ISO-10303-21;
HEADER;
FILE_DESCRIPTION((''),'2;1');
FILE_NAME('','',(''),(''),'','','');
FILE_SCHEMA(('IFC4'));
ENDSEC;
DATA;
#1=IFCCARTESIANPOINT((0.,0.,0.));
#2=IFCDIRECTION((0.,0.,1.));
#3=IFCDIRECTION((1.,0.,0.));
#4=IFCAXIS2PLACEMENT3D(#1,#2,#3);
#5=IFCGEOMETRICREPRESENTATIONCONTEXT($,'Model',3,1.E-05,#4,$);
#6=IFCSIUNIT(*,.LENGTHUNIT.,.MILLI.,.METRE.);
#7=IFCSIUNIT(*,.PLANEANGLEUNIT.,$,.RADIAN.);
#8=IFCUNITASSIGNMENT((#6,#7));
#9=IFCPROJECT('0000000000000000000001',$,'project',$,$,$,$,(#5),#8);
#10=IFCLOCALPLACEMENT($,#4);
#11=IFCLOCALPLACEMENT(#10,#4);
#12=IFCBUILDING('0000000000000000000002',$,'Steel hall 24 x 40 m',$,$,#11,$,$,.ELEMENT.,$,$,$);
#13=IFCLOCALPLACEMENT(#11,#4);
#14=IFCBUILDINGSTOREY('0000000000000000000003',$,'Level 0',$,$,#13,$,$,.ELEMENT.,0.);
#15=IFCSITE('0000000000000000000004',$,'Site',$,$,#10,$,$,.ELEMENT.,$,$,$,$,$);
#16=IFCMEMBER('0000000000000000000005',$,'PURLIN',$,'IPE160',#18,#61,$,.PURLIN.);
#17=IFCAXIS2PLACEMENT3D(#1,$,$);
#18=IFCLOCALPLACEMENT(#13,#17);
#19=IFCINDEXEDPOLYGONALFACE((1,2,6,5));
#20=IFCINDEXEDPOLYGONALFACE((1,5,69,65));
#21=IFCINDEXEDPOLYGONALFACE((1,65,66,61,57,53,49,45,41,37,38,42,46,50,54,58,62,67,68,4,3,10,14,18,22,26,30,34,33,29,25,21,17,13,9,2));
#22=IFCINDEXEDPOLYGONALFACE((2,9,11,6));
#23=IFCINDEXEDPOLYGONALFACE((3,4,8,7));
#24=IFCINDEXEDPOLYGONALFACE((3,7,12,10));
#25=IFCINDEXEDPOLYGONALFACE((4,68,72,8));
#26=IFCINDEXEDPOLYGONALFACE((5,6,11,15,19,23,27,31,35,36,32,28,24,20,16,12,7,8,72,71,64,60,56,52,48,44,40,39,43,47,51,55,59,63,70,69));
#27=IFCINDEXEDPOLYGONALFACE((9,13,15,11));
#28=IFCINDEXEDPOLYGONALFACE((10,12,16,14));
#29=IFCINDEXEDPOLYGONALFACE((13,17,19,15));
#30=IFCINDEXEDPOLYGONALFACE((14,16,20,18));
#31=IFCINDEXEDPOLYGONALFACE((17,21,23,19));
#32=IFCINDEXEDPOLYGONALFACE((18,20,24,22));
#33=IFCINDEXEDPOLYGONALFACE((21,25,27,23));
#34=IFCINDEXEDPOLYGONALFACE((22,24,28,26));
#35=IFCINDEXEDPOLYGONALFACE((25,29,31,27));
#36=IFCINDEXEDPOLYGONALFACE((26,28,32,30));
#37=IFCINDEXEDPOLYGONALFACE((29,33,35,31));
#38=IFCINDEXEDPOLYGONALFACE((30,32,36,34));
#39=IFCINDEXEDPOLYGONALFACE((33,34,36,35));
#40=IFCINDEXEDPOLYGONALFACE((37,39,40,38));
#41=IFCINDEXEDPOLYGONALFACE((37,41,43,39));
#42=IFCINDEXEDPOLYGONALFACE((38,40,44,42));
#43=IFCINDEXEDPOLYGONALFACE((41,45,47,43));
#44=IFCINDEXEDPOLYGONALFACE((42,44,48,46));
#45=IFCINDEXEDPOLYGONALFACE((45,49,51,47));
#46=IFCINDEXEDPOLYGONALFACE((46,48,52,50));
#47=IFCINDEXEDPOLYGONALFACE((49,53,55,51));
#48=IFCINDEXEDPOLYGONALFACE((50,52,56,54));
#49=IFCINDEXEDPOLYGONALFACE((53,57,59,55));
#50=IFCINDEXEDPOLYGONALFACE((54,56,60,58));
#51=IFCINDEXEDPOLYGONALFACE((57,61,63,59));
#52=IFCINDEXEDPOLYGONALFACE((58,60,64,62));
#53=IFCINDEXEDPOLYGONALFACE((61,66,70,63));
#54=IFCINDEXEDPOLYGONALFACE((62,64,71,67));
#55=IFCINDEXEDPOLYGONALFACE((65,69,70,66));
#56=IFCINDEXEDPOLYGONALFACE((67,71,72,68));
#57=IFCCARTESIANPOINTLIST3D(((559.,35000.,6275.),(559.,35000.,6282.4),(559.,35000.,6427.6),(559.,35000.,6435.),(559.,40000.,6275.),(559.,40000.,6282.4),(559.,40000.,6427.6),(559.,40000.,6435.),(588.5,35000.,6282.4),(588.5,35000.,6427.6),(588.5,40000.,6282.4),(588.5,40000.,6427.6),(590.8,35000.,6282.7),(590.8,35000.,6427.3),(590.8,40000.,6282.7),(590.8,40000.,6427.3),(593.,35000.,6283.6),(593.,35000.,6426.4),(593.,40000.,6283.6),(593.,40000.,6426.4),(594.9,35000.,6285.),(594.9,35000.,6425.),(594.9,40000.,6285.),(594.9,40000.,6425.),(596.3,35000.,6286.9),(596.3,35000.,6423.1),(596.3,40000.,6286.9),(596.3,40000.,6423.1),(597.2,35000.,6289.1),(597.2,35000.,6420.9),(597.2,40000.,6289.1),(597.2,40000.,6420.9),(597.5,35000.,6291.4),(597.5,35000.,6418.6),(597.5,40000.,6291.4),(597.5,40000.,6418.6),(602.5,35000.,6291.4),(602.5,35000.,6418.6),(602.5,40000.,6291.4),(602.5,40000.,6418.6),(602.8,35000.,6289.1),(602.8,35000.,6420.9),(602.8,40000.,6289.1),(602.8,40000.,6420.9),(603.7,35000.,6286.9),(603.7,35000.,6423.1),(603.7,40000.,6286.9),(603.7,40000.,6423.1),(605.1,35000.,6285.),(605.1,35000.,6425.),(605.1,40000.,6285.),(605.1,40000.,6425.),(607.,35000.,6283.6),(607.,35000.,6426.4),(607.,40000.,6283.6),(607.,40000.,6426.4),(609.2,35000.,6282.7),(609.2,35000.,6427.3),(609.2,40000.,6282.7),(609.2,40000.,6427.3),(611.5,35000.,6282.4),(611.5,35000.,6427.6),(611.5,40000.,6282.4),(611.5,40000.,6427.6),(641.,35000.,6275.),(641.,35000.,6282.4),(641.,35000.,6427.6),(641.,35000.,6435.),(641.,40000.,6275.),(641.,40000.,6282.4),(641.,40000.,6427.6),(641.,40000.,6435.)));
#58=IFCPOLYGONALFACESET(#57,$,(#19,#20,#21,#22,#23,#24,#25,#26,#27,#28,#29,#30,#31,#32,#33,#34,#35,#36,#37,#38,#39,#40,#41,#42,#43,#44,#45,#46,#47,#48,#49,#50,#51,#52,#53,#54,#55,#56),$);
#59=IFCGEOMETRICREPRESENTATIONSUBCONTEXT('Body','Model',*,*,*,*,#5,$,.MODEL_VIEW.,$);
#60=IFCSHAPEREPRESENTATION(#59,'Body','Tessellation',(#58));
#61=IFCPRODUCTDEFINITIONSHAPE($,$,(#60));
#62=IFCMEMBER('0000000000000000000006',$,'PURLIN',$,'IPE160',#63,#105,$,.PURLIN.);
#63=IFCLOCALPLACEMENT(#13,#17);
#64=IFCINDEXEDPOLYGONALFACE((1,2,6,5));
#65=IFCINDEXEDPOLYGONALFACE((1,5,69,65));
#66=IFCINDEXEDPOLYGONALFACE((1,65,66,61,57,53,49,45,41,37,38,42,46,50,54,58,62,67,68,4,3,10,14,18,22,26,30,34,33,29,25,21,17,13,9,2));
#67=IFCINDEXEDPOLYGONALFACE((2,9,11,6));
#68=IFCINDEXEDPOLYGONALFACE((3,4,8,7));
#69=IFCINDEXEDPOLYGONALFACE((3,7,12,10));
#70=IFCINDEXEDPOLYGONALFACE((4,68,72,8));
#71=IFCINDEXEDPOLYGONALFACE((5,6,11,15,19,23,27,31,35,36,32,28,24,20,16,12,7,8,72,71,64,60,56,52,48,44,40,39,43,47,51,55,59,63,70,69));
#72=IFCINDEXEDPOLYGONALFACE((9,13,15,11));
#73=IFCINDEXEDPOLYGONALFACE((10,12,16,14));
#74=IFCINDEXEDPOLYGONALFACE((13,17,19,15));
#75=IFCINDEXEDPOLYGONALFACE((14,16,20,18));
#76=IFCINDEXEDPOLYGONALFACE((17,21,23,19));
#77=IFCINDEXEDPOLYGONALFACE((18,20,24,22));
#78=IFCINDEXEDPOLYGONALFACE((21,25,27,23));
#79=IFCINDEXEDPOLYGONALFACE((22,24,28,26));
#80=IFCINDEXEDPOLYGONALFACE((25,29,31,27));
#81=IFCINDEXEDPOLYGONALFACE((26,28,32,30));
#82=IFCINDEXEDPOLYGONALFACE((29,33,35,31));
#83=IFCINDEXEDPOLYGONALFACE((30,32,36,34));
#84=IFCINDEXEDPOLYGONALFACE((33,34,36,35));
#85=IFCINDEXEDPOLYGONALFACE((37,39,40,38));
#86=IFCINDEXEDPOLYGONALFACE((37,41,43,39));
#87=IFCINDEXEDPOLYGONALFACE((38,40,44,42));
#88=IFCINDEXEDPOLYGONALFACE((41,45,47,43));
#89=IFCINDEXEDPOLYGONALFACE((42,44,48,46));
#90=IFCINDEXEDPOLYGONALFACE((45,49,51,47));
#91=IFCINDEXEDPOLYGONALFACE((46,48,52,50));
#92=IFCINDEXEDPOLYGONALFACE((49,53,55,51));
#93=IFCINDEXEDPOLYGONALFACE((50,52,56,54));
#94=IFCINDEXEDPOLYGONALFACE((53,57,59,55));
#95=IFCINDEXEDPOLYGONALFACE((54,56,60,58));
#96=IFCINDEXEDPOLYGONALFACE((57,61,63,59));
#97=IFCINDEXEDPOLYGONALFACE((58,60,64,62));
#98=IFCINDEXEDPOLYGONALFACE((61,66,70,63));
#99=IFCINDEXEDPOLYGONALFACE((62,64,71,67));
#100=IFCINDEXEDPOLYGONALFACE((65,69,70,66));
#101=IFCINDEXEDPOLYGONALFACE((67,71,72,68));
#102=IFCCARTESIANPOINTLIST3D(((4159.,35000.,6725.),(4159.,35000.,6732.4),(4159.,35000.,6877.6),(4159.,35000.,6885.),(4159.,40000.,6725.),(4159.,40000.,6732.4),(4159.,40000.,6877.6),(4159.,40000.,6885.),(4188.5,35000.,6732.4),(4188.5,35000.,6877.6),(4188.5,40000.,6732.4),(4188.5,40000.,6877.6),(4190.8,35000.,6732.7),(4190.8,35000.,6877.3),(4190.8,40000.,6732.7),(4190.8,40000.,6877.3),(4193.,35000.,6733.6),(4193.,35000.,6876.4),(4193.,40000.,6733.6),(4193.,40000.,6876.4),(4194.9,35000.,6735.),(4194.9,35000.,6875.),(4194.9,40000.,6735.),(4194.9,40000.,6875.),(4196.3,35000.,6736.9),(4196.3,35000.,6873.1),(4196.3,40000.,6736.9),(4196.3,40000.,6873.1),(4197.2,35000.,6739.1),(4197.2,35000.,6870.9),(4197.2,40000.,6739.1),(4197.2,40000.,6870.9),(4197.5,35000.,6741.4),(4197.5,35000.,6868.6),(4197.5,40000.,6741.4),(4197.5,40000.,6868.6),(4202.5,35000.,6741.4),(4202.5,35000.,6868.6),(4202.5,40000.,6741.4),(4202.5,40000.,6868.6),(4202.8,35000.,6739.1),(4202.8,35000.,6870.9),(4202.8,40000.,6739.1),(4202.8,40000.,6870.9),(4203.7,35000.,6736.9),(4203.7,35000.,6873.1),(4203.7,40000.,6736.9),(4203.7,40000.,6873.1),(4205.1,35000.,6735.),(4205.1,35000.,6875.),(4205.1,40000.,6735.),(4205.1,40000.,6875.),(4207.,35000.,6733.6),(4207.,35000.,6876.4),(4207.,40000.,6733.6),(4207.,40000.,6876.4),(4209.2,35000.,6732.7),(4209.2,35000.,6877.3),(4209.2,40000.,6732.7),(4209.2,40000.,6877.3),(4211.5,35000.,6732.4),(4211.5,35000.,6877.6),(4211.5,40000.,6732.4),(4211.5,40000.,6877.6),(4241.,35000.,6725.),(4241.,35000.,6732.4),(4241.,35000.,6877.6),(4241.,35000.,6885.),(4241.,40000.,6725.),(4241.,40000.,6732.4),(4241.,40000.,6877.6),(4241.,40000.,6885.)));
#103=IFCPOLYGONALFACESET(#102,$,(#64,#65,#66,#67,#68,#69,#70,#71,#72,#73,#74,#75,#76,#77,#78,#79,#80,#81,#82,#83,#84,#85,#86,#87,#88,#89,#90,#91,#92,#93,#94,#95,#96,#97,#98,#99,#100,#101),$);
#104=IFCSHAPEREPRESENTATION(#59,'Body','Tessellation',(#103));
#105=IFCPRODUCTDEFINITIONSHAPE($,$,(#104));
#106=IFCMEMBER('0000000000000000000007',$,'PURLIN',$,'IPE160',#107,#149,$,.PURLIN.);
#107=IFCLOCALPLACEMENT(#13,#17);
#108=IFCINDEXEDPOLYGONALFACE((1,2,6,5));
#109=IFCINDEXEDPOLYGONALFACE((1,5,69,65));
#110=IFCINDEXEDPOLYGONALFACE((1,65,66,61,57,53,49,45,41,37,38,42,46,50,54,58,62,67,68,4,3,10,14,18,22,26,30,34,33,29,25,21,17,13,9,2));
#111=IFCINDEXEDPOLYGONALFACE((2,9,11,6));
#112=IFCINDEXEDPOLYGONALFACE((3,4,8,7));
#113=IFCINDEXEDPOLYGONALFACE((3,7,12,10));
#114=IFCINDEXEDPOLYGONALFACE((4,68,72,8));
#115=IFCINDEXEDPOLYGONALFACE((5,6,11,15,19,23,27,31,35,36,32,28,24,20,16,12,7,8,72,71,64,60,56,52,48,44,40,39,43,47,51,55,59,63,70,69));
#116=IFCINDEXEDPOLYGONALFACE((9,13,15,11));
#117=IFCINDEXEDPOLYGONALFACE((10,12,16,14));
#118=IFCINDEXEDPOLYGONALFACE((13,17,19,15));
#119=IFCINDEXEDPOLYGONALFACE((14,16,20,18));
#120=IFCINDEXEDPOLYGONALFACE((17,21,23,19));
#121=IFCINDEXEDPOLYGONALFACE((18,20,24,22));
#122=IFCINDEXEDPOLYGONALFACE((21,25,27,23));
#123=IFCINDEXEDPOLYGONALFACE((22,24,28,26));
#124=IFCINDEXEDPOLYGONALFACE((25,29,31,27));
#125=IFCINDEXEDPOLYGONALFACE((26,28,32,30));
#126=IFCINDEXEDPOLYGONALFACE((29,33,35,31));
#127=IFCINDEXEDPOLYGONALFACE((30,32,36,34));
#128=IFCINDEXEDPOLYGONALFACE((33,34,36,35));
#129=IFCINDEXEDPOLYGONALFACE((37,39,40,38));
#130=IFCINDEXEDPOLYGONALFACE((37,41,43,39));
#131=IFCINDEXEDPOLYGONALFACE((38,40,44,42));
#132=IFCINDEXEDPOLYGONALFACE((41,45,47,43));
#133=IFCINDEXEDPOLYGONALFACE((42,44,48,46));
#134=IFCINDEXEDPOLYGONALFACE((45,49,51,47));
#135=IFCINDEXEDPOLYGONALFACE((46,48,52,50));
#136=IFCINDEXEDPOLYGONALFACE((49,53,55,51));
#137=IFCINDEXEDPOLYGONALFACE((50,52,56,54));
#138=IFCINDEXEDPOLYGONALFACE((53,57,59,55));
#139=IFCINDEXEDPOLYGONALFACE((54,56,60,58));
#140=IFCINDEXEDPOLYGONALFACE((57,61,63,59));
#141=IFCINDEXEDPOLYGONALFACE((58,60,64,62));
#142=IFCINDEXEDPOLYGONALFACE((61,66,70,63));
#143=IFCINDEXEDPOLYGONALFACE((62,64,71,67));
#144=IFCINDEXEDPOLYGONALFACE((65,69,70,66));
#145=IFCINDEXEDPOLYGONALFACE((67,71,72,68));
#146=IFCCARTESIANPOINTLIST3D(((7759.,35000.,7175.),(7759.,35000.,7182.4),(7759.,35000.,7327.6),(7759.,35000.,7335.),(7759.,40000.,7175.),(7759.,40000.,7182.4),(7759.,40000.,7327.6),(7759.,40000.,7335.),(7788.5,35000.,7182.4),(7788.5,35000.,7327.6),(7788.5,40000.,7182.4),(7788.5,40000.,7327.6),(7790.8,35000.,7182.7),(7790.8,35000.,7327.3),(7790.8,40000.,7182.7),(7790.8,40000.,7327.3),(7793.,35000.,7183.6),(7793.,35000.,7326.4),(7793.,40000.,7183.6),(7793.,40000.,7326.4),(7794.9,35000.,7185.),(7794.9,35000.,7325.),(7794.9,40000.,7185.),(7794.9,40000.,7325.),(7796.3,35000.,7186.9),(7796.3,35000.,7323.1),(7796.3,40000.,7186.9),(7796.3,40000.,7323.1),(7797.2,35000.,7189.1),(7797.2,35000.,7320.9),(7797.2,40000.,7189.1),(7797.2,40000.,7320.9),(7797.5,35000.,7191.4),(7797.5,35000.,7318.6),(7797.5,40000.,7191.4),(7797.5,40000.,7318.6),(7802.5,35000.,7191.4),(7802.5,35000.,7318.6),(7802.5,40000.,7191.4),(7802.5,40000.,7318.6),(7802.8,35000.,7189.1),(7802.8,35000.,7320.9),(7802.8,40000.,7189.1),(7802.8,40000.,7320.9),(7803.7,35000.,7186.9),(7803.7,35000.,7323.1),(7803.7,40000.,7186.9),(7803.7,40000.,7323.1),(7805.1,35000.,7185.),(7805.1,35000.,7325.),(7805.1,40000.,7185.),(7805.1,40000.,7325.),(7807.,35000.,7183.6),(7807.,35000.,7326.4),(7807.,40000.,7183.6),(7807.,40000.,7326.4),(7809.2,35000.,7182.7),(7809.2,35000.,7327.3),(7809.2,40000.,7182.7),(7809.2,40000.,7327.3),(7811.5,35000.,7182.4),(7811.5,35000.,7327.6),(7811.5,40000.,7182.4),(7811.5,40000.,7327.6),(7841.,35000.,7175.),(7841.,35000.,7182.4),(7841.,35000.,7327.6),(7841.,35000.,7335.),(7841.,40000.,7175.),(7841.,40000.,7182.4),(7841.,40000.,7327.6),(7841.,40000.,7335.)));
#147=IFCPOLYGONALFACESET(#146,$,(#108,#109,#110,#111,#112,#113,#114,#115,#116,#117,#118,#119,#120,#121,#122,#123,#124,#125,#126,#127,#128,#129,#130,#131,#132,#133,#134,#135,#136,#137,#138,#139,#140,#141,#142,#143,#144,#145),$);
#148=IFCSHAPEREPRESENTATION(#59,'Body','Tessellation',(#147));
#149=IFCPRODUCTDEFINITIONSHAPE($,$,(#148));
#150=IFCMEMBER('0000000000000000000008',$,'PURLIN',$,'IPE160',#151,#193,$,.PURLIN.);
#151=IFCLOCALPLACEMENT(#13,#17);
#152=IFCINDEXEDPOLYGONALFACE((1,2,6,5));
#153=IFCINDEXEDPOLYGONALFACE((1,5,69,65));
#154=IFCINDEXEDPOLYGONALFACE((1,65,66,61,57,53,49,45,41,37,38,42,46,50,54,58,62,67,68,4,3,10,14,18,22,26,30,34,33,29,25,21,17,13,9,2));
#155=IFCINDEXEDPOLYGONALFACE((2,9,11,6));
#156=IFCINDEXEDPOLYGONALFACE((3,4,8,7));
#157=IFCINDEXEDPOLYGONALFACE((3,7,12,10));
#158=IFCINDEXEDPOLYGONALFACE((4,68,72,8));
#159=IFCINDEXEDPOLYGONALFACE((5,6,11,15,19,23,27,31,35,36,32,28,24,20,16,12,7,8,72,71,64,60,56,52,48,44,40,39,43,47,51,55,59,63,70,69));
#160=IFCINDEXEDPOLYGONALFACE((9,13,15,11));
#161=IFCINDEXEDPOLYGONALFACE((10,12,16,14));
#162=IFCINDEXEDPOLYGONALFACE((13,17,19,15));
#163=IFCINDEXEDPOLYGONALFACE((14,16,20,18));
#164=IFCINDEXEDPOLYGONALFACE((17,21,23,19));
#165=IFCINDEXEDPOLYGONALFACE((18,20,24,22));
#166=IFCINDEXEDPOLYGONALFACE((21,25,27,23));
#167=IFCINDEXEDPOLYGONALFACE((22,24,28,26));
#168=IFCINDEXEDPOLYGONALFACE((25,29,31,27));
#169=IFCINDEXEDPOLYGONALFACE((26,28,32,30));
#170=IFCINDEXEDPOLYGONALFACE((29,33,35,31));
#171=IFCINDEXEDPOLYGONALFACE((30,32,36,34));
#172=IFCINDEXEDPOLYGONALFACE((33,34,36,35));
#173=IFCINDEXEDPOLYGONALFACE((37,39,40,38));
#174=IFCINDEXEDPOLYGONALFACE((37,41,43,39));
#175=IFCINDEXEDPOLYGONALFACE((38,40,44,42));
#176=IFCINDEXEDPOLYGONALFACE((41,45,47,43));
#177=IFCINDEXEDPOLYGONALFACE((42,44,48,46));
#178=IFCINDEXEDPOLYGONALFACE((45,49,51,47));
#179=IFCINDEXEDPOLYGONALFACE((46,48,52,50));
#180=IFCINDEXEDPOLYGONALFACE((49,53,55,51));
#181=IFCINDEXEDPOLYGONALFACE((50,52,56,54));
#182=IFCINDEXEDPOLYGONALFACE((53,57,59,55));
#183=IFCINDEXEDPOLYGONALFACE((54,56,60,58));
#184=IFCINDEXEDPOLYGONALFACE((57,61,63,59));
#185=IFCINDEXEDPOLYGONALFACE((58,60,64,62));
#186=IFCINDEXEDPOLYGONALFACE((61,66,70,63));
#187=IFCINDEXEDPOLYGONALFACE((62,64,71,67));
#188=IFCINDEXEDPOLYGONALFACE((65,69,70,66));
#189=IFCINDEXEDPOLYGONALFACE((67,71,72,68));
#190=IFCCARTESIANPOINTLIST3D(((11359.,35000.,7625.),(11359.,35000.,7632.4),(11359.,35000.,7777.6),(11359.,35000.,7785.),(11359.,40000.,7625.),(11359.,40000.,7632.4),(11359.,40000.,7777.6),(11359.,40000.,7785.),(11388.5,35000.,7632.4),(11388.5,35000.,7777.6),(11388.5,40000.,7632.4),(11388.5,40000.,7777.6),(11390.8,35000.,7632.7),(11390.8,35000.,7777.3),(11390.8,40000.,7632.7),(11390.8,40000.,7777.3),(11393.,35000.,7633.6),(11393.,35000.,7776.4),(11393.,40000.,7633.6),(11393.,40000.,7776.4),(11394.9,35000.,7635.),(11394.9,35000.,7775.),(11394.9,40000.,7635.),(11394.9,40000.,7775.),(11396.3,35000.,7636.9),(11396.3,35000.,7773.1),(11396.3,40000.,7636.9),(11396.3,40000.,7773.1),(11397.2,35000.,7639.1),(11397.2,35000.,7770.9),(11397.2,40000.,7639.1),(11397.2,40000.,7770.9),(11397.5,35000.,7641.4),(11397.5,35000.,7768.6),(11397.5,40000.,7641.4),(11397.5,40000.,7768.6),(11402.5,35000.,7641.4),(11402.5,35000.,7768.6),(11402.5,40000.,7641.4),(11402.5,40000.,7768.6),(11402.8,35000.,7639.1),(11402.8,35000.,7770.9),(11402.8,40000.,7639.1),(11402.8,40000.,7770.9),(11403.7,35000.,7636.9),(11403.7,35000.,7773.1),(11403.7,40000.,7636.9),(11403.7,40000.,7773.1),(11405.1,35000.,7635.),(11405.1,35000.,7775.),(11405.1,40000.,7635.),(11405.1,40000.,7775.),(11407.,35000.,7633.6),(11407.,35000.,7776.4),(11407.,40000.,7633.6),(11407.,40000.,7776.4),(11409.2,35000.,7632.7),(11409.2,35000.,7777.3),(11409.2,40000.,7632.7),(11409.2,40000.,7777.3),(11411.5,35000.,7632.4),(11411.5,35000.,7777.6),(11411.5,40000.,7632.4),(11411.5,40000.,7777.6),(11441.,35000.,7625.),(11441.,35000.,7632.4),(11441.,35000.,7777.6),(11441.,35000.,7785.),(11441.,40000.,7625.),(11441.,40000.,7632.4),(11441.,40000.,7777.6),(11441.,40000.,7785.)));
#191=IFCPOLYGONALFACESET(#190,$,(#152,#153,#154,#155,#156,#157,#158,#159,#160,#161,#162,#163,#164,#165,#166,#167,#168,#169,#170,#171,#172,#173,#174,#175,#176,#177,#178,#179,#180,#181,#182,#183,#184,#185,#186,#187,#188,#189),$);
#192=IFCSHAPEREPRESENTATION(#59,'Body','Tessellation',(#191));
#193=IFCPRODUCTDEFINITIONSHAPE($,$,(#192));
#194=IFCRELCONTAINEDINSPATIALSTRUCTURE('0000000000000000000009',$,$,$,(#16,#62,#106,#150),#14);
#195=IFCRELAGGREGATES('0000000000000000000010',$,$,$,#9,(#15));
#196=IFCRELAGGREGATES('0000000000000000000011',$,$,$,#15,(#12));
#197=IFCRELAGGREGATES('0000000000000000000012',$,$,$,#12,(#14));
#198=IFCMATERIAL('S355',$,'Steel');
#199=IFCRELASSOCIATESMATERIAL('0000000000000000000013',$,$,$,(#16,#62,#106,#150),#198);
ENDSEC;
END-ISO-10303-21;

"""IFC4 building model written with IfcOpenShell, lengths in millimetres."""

from ifc_helpers import new_model, si_unit, frame, origin_with_axes, place, context, subcontext, project, spatial, i_section, extrude, material, element, save


model = new_model("IFC4")

# Units and contexts
model_context = context("Model", 3, precision=1e-05, world=origin_with_axes())
body_context = subcontext(model_context, "Body", "Model", "MODEL_VIEW")
ifc_project = project(units=[si_unit("LENGTHUNIT", "METRE", prefix="MILLI"), si_unit("PLANEANGLEUNIT", "RADIAN")], contexts=[model_context])

# Site, building, storey
site_placement = place(None, origin_with_axes())
site = spatial("IfcSite", under=ifc_project, at=site_placement, Name="Site", CompositionType="ELEMENT")
building_placement = place(site_placement, origin_with_axes())
building = spatial("IfcBuilding", under=site, at=building_placement, Name="Steel hall 24 x 40 m", CompositionType="ELEMENT")
storey_placement = place(building_placement, origin_with_axes())
storey = spatial("IfcBuildingStorey", under=building, at=storey_placement, Name="Level 0", CompositionType="ELEMENT", Elevation=0.0)

# Shared definitions
ifc_material = material(Name="S355", Category="Steel")

# Members
for number, where, z_axis, x_axis, name in (
    (1, (600.0, 35000.0, 6355.0), (0.0, 1.0, 0.0), (1.0, 0.0, 0.0), "PURLIN"),
    (2, (4200.0, 35000.0, 6805.0), (0.0, 1.0, 0.0), (1.0, 0.0, 0.0), "PURLIN"),
    (3, (7800.0, 35000.0, 7255.0), (0.0, 1.0, 0.0), (1.0, 0.0, 0.0), "PURLIN"),
    (4, (11400.0, 35000.0, 7705.0), (0.0, 1.0, 0.0), (1.0, 0.0, 0.0), "PURLIN"),
):
    element("IfcMember", number, at=place(storey_placement, frame(where, z_axis=z_axis, x_axis=x_axis)), inside=storey, material=ifc_material, Name=name, ObjectType="IPE160", PredefinedType="PURLIN", context=body_context, shape_type="SweptSolid", body=[
        extrude(i_section(OverallWidth=82.0, OverallDepth=160.0, WebThickness=5.0, FlangeThickness=7.4, FilletRadius=9.0), origin_with_axes(), (0.0, 0.0, 1.0), 5000.0),
    ])

save(model, "model.ifc")
